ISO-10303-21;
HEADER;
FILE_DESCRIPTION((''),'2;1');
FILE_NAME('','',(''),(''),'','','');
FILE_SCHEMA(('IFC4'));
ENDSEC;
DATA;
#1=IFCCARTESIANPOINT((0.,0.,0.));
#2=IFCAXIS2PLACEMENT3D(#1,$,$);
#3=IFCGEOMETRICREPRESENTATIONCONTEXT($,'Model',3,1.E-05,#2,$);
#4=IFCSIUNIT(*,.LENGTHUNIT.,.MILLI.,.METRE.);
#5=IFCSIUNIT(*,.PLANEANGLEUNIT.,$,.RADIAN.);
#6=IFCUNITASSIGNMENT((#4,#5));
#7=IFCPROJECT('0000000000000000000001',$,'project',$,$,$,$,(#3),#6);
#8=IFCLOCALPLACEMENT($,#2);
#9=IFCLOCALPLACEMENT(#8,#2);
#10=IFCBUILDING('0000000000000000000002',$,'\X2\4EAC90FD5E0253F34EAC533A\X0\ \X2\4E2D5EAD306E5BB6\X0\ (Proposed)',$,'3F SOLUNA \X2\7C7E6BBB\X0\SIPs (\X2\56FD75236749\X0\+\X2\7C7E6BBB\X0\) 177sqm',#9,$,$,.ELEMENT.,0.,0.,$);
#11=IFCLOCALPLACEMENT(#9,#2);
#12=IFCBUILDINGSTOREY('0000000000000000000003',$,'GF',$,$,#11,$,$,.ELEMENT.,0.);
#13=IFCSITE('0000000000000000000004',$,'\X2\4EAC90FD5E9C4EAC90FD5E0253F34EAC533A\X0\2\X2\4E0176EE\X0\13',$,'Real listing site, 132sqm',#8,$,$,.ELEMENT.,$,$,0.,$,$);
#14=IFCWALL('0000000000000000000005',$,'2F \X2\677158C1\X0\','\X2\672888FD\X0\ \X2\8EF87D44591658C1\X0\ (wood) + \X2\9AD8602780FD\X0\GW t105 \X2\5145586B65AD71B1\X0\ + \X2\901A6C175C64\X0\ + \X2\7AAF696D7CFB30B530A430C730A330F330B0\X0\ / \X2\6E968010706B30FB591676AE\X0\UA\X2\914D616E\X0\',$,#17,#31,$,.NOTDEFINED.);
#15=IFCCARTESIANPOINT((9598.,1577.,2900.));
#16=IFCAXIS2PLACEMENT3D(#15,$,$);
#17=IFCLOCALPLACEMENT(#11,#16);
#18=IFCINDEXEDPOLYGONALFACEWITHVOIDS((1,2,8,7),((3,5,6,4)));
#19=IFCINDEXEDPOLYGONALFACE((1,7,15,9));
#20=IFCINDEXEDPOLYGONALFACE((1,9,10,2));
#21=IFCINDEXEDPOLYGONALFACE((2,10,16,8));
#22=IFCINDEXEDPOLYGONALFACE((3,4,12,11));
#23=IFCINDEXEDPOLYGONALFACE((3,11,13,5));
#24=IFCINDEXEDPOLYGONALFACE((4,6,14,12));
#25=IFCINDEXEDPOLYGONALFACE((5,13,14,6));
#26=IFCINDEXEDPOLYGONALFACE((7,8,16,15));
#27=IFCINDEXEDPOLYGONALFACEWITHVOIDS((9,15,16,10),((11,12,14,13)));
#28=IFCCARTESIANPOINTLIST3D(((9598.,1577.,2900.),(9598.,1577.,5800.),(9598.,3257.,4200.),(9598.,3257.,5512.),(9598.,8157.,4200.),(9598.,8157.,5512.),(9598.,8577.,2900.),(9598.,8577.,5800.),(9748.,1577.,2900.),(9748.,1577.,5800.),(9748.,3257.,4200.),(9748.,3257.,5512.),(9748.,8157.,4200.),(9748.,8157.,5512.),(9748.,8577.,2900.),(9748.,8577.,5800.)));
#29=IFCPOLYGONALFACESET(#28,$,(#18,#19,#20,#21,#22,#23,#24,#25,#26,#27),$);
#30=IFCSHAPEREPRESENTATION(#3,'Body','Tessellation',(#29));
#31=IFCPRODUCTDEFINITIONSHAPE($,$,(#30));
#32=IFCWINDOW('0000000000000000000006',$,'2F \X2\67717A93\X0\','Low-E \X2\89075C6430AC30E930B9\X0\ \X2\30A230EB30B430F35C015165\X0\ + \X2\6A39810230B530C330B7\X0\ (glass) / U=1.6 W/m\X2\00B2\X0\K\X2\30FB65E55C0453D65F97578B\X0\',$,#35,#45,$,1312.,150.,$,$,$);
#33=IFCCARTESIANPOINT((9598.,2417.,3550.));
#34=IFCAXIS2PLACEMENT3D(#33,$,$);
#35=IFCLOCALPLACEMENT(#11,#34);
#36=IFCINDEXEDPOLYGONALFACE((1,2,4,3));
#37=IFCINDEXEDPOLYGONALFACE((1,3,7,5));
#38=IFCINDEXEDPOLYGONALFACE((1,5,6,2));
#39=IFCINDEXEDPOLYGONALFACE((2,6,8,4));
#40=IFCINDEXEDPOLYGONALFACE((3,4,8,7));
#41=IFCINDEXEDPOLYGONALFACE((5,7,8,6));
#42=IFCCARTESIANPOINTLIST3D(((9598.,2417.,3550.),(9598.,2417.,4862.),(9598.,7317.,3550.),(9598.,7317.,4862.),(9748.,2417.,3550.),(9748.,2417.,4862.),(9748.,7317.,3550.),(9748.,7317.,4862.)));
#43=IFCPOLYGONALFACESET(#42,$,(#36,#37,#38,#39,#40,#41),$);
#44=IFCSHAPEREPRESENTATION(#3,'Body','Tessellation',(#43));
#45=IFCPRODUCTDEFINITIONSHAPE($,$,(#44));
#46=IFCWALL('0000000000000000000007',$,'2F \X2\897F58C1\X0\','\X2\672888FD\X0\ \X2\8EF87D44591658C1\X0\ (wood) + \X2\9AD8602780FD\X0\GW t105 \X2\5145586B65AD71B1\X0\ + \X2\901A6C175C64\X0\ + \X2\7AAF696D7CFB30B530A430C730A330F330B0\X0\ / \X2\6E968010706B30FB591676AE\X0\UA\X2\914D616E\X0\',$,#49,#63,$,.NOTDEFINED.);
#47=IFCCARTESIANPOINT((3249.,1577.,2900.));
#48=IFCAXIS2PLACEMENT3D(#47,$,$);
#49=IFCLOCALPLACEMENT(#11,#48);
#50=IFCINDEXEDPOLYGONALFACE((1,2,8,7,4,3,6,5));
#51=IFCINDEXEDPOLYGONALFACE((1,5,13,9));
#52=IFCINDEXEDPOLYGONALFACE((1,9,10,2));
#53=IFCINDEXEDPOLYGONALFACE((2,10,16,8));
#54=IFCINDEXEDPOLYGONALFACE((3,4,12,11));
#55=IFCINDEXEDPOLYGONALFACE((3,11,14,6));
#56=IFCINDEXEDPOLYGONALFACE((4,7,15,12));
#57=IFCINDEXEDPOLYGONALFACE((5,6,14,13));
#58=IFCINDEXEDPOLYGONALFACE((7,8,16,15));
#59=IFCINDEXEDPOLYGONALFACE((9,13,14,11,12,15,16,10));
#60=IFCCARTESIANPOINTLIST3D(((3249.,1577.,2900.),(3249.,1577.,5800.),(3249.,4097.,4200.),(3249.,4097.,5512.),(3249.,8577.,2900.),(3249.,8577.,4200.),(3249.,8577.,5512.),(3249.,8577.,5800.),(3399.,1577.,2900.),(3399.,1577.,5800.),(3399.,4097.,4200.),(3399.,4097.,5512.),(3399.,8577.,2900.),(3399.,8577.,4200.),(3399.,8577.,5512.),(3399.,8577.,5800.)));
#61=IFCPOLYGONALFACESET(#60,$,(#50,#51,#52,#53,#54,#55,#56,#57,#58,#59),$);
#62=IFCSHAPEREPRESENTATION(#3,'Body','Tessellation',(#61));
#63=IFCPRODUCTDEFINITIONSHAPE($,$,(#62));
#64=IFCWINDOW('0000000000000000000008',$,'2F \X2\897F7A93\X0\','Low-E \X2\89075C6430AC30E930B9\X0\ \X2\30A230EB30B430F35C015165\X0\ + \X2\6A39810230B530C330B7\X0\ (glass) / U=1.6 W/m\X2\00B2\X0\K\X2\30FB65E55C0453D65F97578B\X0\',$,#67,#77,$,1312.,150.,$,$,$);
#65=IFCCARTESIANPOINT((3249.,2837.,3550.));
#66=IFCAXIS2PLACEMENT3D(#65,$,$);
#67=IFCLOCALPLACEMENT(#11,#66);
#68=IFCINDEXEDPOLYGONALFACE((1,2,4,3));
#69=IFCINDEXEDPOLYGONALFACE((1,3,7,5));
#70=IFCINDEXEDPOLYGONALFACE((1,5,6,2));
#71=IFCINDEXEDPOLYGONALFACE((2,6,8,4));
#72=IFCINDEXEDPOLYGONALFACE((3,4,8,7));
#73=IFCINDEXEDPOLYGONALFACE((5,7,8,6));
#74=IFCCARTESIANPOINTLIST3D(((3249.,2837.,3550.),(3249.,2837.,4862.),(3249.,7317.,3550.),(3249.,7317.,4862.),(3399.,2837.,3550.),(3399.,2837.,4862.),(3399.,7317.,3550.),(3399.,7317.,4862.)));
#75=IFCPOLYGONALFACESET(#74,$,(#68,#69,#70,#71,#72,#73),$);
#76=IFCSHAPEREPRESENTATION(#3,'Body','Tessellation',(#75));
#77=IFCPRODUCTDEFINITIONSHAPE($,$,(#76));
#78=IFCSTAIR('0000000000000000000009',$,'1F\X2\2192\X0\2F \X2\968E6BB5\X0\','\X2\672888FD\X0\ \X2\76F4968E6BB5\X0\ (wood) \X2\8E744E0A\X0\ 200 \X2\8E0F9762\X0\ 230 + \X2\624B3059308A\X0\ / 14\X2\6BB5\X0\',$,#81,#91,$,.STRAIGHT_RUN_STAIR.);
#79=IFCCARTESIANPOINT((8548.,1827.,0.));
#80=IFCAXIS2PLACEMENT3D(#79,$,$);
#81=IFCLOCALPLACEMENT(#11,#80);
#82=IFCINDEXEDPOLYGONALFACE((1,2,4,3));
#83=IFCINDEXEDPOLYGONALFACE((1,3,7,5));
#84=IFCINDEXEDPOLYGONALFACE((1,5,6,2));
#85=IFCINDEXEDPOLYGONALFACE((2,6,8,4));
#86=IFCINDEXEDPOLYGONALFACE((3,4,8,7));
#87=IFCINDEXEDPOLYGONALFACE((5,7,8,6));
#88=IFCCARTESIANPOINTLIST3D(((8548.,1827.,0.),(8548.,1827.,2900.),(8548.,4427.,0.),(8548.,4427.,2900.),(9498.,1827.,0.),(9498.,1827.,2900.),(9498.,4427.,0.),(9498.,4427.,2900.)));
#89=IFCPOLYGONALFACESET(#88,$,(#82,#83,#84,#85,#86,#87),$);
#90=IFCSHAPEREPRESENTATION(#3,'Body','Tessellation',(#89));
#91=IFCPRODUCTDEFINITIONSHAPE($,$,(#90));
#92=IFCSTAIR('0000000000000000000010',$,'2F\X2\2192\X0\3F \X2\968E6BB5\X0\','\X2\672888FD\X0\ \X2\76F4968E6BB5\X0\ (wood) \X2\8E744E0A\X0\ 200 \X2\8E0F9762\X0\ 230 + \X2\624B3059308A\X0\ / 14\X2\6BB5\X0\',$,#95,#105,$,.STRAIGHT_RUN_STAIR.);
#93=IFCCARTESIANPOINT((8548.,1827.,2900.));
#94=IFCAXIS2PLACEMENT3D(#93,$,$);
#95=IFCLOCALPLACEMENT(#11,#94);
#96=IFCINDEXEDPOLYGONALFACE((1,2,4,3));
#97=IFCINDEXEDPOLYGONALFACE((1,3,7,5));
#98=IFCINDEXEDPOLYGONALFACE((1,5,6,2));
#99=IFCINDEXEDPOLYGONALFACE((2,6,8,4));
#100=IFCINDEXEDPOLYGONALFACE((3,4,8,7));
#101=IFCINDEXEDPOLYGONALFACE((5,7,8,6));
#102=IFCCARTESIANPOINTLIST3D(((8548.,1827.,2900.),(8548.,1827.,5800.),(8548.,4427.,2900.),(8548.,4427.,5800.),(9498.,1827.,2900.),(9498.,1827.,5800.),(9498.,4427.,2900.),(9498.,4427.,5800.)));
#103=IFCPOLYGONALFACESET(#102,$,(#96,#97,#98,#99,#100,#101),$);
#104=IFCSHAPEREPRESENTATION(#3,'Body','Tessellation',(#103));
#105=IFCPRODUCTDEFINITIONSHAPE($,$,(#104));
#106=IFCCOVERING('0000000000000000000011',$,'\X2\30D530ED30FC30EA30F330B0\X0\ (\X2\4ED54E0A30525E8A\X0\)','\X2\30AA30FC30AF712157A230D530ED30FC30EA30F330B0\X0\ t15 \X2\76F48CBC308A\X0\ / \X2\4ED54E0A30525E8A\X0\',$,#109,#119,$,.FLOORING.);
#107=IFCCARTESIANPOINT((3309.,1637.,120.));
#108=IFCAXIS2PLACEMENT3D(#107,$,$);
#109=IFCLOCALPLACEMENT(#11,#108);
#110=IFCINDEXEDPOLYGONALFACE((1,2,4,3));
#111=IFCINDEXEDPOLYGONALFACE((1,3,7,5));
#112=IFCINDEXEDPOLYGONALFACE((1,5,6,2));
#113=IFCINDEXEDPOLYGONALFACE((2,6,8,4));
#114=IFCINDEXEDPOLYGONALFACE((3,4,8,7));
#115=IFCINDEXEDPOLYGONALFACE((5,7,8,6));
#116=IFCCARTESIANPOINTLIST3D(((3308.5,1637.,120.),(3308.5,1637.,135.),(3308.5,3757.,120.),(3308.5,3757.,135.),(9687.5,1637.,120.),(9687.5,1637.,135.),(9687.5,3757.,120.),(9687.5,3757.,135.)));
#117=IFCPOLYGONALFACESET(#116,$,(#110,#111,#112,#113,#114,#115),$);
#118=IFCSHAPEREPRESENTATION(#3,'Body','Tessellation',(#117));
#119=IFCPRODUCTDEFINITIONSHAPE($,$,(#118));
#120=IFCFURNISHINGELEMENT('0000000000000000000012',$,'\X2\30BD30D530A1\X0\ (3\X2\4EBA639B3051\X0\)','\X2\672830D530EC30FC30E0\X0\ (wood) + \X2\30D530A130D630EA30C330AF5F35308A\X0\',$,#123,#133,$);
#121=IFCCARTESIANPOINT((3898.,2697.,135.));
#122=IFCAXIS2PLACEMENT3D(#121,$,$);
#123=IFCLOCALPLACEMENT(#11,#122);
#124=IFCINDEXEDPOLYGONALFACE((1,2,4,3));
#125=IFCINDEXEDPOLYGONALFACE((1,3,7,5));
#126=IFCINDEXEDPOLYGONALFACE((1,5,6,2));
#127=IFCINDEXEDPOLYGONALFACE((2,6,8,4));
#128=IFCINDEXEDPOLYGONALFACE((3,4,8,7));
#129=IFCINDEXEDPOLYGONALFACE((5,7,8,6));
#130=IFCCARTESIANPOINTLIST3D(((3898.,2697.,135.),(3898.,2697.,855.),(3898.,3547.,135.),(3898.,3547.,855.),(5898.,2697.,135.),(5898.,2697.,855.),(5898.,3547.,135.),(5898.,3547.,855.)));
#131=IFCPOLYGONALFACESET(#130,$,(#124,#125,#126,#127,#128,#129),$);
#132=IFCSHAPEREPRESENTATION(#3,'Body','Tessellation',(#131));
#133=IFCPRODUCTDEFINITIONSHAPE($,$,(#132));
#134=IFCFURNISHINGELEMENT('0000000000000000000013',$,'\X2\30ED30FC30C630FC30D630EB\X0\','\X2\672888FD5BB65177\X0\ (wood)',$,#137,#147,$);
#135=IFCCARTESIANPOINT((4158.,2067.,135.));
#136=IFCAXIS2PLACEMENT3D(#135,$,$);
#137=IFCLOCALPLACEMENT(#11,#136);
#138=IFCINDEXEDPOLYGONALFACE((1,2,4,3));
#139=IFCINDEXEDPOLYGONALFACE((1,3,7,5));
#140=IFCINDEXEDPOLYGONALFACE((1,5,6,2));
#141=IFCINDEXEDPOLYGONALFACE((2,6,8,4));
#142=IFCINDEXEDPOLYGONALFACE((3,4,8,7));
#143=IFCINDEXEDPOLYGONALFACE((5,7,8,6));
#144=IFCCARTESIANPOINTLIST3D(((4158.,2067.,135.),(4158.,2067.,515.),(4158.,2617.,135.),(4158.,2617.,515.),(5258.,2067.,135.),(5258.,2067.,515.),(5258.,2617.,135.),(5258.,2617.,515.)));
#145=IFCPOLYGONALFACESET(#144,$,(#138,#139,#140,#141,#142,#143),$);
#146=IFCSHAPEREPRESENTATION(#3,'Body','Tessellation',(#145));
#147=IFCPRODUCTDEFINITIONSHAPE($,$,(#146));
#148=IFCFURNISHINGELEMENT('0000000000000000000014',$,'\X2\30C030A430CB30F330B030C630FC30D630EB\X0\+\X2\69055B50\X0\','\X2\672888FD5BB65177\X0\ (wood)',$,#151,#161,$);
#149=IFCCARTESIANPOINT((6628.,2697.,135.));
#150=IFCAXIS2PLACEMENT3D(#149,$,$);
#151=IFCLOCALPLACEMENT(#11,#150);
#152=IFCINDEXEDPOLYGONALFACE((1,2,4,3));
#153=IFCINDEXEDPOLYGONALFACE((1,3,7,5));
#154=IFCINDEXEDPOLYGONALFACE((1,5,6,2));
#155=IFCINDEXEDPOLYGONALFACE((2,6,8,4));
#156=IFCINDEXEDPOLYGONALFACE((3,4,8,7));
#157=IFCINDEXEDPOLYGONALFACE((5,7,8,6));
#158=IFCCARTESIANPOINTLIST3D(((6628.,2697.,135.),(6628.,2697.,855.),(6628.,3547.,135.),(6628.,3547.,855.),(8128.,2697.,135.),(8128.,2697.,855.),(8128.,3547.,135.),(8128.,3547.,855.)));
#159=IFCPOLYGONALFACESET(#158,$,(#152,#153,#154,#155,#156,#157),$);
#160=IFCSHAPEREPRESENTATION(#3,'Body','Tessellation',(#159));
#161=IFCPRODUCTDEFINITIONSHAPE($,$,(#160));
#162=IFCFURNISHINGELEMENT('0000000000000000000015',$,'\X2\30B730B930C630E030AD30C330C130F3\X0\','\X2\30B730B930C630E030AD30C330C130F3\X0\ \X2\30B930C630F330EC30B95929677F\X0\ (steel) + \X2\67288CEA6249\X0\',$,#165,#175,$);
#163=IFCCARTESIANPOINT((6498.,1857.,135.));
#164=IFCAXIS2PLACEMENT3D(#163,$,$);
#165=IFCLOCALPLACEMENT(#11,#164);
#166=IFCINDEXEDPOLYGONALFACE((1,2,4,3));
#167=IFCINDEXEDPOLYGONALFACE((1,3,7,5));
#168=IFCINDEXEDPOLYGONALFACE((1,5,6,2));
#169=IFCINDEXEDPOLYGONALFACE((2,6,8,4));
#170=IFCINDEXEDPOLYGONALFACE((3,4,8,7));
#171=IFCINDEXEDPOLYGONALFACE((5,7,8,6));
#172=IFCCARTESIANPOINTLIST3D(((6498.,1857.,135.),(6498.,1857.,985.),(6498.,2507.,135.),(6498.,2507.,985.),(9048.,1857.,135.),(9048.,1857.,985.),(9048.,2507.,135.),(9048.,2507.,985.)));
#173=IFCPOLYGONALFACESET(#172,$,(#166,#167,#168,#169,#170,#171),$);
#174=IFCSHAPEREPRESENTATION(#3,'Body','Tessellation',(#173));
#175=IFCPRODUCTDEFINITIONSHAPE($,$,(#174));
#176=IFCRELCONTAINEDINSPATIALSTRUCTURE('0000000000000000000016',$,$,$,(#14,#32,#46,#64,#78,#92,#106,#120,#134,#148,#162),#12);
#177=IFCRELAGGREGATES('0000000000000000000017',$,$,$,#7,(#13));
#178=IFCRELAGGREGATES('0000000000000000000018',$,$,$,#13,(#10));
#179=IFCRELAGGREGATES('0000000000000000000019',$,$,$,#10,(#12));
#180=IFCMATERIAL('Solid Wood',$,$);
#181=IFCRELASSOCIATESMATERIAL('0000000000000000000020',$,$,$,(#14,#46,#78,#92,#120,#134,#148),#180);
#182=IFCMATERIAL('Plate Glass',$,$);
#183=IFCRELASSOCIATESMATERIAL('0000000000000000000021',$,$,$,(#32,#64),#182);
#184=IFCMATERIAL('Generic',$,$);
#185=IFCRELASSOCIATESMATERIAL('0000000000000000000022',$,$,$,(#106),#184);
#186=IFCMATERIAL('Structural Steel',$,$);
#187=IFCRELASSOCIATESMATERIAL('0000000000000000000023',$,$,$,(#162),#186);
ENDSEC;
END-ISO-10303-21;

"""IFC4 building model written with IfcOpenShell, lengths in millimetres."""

from ifc_helpers import new_model, si_unit, frame, frame_2d, origin, place, context, project, spatial, rectangle, extrude, material, element, fill, save


model = new_model("IFC4")

# Units and contexts
model_context = context("Model", 3, precision=1e-05, world=origin())
ifc_project = project(units=[si_unit("LENGTHUNIT", "METRE", prefix="MILLI"), si_unit("PLANEANGLEUNIT", "RADIAN")], contexts=[model_context])

# Site, building, storey
site_placement = place(None, origin())
site = spatial("IfcSite", under=ifc_project, at=site_placement, Name="京都府京都市右京区2丁目13", ObjectType="Real listing site, 132sqm", CompositionType="ELEMENT", RefElevation=0.0)
building_placement = place(site_placement, origin())
building = spatial("IfcBuilding", under=site, at=building_placement, Name="京都市右京区 中庭の家 (Proposed)", ObjectType="3F SOLUNA 籾殻SIPs (国産杉+籾殻) 177sqm", CompositionType="ELEMENT", ElevationOfRefHeight=0.0, ElevationOfTerrain=0.0)
storey_placement = place(building_placement, origin())
storey = spatial("IfcBuildingStorey", under=building, at=storey_placement, Name="GF", CompositionType="ELEMENT", Elevation=0.0)

# Shared definitions
ifc_material_1 = material(Name="Solid Wood")
ifc_material_2 = material(Name="Generic")

# Shared definitions
ifc_material_3 = material(Name="Plate Glass")

# Walls, openings, windows
wall_1_placement = place(storey_placement, frame((9598.0, 1577.0, 2900.0)))
wall_1 = element("IfcWall", 1, at=wall_1_placement, inside=storey, material=ifc_material_1, Name="2F 東壁", Description="木製 軸組外壁 (wood) + 高性能GW t105 充填断熱 + 通気層 + 窯業系サイディング / 準耐火・外皮UA配慮", PredefinedType="NOTDEFINED", context=model_context, shape_type="SweptSolid", body=[
    extrude(rectangle(XDim=150.0, YDim=7000.0, at=frame_2d((75.0, 3500.0))), frame((9598.0, 1577.0, 2900.0)), (0.0, 0.0, 1.0), 2900.0),
])
opening_1_placement = place(storey_placement, frame((9598.0, 2417.0, 3550.0)))
opening_1 = element("IfcOpeningElement", 2, at=opening_1_placement, cuts=wall_1, PredefinedType="NOTDEFINED", context=model_context, shape_type="SweptSolid", body=[
    extrude(rectangle(XDim=150.0, YDim=4900.0, at=frame_2d((75.0, 2450.0))), frame((9598.0, 2417.0, 3550.0)), (0.0, 0.0, 1.0), 1312.0),
])
window_1_placement = place(storey_placement, frame((9598.0, 2417.0, 3550.0)))
window_1 = element("IfcWindow", 3, at=window_1_placement, inside=storey, material=ifc_material_3, Name="2F 東窓", Description="Low-E 複層ガラス アルゴン封入 + 樹脂サッシ (glass) / U=1.6 W/m²K・日射取得型", OverallHeight=1312.0, OverallWidth=150.0, context=model_context, shape_type="SweptSolid", body=[
    extrude(rectangle(XDim=150.0, YDim=4900.0, at=frame_2d((75.0, 2450.0))), frame((9598.0, 2417.0, 3550.0)), (0.0, 0.0, 1.0), 1312.0),
])
fill(opening_1, window_1)
wall_2_placement = place(storey_placement, frame((3249.0, 1577.0, 2900.0)))
wall_2 = element("IfcWall", 4, at=wall_2_placement, inside=storey, material=ifc_material_1, Name="2F 西壁", Description="木製 軸組外壁 (wood) + 高性能GW t105 充填断熱 + 通気層 + 窯業系サイディング / 準耐火・外皮UA配慮", PredefinedType="NOTDEFINED", context=model_context, shape_type="SweptSolid", body=[
    extrude(rectangle(XDim=150.0, YDim=7000.0, at=frame_2d((75.0, 3500.0))), frame((3249.0, 1577.0, 2900.0)), (0.0, 0.0, 1.0), 2900.0),
])
opening_2_placement = place(storey_placement, frame((3249.0, 2837.0, 3550.0)))
opening_2 = element("IfcOpeningElement", 5, at=opening_2_placement, cuts=wall_2, PredefinedType="NOTDEFINED", context=model_context, shape_type="SweptSolid", body=[
    extrude(rectangle(XDim=150.0, YDim=4480.0, at=frame_2d((75.0, 2240.0))), frame((3249.0, 2837.0, 3550.0)), (0.0, 0.0, 1.0), 1312.0),
])
window_2_placement = place(storey_placement, frame((3249.0, 2837.0, 3550.0)))
window_2 = element("IfcWindow", 6, at=window_2_placement, inside=storey, material=ifc_material_3, Name="2F 西窓", Description="Low-E 複層ガラス アルゴン封入 + 樹脂サッシ (glass) / U=1.6 W/m²K・日射取得型", OverallHeight=1312.0, OverallWidth=150.0, context=model_context, shape_type="SweptSolid", body=[
    extrude(rectangle(XDim=150.0, YDim=4480.0, at=frame_2d((75.0, 2240.0))), frame((3249.0, 2837.0, 3550.0)), (0.0, 0.0, 1.0), 1312.0),
])
fill(opening_2, window_2)

# Stairs
stair_1_placement = place(storey_placement, frame((8548.0, 1827.0, 0.0)))
element("IfcStair", 7, at=stair_1_placement, inside=storey, material=ifc_material_1, Name="1F→2F 階段", Description="木製 直階段 (wood) 蹴上 200 踏面 230 + 手すり / 14段", PredefinedType="STRAIGHT_RUN_STAIR", context=model_context, shape_type="SweptSolid", body=[
    extrude(rectangle(XDim=950.0, YDim=2600.0, at=frame_2d((475.0, 1300.0))), frame((8548.0, 1827.0, 0.0)), (0.0, 0.0, 1.0), 2900.0),
])
stair_2_placement = place(storey_placement, frame((8548.0, 1827.0, 2900.0)))
element("IfcStair", 8, at=stair_2_placement, inside=storey, material=ifc_material_1, Name="2F→3F 階段", Description="木製 直階段 (wood) 蹴上 200 踏面 230 + 手すり / 14段", PredefinedType="STRAIGHT_RUN_STAIR", context=model_context, shape_type="SweptSolid", body=[
    extrude(rectangle(XDim=950.0, YDim=2600.0, at=frame_2d((475.0, 1300.0))), frame((8548.0, 1827.0, 2900.0)), (0.0, 0.0, 1.0), 2900.0),
])

# Covering
covering_placement = place(storey_placement, frame((3309.0, 1637.0, 120.0)))
element("IfcCovering", 9, at=covering_placement, inside=storey, material=ifc_material_2, Name="フローリング (仕上げ床)", Description="オーク無垢フローリング t15 直貼り / 仕上げ床", PredefinedType="FLOORING", context=model_context, shape_type="SweptSolid", body=[
    extrude(rectangle(XDim=6379.0, YDim=2120.0, at=frame_2d((3189.0, 1060.0))), frame((3309.0, 1637.0, 120.0)), (0.0, 0.0, 1.0), 15.0),
])

# Furnishing elements
furnishing_1_placement = place(storey_placement, frame((3898.0, 2697.0, 135.0)))
element("IfcFurnishingElement", 10, at=furnishing_1_placement, inside=storey, material=ifc_material_1, Name="ソファ (3人掛け)", Description="木フレーム (wood) + ファブリック張り", context=model_context, shape_type="SweptSolid", body=[
    extrude(rectangle(XDim=2000.0, YDim=850.0, at=frame_2d((1000.0, 425.0))), frame((3898.0, 2697.0, 135.0)), (0.0, 0.0, 1.0), 720.0),
])
furnishing_2_placement = place(storey_placement, frame((4158.0, 2067.0, 135.0)))
element("IfcFurnishingElement", 11, at=furnishing_2_placement, inside=storey, material=ifc_material_1, Name="ローテーブル", Description="木製家具 (wood)", context=model_context, shape_type="SweptSolid", body=[
    extrude(rectangle(XDim=1100.0, YDim=550.0, at=frame_2d((550.0, 275.0))), frame((4158.0, 2067.0, 135.0)), (0.0, 0.0, 1.0), 380.0),
])
furnishing_3_placement = place(storey_placement, frame((6628.0, 2697.0, 135.0)))
element("IfcFurnishingElement", 12, at=furnishing_3_placement, inside=storey, material=ifc_material_1, Name="ダイニングテーブル+椅子", Description="木製家具 (wood)", context=model_context, shape_type="SweptSolid", body=[
    extrude(rectangle(XDim=1500.0, YDim=850.0, at=frame_2d((750.0, 425.0))), frame((6628.0, 2697.0, 135.0)), (0.0, 0.0, 1.0), 720.0),
])
ifc_material_4 = material(Name="Structural Steel")
furnishing_4_placement = place(storey_placement, frame((6498.0, 1857.0, 135.0)))
element("IfcFurnishingElement", 13, at=furnishing_4_placement, inside=storey, material=ifc_material_4, Name="システムキッチン", Description="システムキッチン ステンレス天板 (steel) + 木質扉", context=model_context, shape_type="SweptSolid", body=[
    extrude(rectangle(XDim=2550.0, YDim=650.0, at=frame_2d((1275.0, 325.0))), frame((6498.0, 1857.0, 135.0)), (0.0, 0.0, 1.0), 850.0),
])

save(model, "model.ifc")
